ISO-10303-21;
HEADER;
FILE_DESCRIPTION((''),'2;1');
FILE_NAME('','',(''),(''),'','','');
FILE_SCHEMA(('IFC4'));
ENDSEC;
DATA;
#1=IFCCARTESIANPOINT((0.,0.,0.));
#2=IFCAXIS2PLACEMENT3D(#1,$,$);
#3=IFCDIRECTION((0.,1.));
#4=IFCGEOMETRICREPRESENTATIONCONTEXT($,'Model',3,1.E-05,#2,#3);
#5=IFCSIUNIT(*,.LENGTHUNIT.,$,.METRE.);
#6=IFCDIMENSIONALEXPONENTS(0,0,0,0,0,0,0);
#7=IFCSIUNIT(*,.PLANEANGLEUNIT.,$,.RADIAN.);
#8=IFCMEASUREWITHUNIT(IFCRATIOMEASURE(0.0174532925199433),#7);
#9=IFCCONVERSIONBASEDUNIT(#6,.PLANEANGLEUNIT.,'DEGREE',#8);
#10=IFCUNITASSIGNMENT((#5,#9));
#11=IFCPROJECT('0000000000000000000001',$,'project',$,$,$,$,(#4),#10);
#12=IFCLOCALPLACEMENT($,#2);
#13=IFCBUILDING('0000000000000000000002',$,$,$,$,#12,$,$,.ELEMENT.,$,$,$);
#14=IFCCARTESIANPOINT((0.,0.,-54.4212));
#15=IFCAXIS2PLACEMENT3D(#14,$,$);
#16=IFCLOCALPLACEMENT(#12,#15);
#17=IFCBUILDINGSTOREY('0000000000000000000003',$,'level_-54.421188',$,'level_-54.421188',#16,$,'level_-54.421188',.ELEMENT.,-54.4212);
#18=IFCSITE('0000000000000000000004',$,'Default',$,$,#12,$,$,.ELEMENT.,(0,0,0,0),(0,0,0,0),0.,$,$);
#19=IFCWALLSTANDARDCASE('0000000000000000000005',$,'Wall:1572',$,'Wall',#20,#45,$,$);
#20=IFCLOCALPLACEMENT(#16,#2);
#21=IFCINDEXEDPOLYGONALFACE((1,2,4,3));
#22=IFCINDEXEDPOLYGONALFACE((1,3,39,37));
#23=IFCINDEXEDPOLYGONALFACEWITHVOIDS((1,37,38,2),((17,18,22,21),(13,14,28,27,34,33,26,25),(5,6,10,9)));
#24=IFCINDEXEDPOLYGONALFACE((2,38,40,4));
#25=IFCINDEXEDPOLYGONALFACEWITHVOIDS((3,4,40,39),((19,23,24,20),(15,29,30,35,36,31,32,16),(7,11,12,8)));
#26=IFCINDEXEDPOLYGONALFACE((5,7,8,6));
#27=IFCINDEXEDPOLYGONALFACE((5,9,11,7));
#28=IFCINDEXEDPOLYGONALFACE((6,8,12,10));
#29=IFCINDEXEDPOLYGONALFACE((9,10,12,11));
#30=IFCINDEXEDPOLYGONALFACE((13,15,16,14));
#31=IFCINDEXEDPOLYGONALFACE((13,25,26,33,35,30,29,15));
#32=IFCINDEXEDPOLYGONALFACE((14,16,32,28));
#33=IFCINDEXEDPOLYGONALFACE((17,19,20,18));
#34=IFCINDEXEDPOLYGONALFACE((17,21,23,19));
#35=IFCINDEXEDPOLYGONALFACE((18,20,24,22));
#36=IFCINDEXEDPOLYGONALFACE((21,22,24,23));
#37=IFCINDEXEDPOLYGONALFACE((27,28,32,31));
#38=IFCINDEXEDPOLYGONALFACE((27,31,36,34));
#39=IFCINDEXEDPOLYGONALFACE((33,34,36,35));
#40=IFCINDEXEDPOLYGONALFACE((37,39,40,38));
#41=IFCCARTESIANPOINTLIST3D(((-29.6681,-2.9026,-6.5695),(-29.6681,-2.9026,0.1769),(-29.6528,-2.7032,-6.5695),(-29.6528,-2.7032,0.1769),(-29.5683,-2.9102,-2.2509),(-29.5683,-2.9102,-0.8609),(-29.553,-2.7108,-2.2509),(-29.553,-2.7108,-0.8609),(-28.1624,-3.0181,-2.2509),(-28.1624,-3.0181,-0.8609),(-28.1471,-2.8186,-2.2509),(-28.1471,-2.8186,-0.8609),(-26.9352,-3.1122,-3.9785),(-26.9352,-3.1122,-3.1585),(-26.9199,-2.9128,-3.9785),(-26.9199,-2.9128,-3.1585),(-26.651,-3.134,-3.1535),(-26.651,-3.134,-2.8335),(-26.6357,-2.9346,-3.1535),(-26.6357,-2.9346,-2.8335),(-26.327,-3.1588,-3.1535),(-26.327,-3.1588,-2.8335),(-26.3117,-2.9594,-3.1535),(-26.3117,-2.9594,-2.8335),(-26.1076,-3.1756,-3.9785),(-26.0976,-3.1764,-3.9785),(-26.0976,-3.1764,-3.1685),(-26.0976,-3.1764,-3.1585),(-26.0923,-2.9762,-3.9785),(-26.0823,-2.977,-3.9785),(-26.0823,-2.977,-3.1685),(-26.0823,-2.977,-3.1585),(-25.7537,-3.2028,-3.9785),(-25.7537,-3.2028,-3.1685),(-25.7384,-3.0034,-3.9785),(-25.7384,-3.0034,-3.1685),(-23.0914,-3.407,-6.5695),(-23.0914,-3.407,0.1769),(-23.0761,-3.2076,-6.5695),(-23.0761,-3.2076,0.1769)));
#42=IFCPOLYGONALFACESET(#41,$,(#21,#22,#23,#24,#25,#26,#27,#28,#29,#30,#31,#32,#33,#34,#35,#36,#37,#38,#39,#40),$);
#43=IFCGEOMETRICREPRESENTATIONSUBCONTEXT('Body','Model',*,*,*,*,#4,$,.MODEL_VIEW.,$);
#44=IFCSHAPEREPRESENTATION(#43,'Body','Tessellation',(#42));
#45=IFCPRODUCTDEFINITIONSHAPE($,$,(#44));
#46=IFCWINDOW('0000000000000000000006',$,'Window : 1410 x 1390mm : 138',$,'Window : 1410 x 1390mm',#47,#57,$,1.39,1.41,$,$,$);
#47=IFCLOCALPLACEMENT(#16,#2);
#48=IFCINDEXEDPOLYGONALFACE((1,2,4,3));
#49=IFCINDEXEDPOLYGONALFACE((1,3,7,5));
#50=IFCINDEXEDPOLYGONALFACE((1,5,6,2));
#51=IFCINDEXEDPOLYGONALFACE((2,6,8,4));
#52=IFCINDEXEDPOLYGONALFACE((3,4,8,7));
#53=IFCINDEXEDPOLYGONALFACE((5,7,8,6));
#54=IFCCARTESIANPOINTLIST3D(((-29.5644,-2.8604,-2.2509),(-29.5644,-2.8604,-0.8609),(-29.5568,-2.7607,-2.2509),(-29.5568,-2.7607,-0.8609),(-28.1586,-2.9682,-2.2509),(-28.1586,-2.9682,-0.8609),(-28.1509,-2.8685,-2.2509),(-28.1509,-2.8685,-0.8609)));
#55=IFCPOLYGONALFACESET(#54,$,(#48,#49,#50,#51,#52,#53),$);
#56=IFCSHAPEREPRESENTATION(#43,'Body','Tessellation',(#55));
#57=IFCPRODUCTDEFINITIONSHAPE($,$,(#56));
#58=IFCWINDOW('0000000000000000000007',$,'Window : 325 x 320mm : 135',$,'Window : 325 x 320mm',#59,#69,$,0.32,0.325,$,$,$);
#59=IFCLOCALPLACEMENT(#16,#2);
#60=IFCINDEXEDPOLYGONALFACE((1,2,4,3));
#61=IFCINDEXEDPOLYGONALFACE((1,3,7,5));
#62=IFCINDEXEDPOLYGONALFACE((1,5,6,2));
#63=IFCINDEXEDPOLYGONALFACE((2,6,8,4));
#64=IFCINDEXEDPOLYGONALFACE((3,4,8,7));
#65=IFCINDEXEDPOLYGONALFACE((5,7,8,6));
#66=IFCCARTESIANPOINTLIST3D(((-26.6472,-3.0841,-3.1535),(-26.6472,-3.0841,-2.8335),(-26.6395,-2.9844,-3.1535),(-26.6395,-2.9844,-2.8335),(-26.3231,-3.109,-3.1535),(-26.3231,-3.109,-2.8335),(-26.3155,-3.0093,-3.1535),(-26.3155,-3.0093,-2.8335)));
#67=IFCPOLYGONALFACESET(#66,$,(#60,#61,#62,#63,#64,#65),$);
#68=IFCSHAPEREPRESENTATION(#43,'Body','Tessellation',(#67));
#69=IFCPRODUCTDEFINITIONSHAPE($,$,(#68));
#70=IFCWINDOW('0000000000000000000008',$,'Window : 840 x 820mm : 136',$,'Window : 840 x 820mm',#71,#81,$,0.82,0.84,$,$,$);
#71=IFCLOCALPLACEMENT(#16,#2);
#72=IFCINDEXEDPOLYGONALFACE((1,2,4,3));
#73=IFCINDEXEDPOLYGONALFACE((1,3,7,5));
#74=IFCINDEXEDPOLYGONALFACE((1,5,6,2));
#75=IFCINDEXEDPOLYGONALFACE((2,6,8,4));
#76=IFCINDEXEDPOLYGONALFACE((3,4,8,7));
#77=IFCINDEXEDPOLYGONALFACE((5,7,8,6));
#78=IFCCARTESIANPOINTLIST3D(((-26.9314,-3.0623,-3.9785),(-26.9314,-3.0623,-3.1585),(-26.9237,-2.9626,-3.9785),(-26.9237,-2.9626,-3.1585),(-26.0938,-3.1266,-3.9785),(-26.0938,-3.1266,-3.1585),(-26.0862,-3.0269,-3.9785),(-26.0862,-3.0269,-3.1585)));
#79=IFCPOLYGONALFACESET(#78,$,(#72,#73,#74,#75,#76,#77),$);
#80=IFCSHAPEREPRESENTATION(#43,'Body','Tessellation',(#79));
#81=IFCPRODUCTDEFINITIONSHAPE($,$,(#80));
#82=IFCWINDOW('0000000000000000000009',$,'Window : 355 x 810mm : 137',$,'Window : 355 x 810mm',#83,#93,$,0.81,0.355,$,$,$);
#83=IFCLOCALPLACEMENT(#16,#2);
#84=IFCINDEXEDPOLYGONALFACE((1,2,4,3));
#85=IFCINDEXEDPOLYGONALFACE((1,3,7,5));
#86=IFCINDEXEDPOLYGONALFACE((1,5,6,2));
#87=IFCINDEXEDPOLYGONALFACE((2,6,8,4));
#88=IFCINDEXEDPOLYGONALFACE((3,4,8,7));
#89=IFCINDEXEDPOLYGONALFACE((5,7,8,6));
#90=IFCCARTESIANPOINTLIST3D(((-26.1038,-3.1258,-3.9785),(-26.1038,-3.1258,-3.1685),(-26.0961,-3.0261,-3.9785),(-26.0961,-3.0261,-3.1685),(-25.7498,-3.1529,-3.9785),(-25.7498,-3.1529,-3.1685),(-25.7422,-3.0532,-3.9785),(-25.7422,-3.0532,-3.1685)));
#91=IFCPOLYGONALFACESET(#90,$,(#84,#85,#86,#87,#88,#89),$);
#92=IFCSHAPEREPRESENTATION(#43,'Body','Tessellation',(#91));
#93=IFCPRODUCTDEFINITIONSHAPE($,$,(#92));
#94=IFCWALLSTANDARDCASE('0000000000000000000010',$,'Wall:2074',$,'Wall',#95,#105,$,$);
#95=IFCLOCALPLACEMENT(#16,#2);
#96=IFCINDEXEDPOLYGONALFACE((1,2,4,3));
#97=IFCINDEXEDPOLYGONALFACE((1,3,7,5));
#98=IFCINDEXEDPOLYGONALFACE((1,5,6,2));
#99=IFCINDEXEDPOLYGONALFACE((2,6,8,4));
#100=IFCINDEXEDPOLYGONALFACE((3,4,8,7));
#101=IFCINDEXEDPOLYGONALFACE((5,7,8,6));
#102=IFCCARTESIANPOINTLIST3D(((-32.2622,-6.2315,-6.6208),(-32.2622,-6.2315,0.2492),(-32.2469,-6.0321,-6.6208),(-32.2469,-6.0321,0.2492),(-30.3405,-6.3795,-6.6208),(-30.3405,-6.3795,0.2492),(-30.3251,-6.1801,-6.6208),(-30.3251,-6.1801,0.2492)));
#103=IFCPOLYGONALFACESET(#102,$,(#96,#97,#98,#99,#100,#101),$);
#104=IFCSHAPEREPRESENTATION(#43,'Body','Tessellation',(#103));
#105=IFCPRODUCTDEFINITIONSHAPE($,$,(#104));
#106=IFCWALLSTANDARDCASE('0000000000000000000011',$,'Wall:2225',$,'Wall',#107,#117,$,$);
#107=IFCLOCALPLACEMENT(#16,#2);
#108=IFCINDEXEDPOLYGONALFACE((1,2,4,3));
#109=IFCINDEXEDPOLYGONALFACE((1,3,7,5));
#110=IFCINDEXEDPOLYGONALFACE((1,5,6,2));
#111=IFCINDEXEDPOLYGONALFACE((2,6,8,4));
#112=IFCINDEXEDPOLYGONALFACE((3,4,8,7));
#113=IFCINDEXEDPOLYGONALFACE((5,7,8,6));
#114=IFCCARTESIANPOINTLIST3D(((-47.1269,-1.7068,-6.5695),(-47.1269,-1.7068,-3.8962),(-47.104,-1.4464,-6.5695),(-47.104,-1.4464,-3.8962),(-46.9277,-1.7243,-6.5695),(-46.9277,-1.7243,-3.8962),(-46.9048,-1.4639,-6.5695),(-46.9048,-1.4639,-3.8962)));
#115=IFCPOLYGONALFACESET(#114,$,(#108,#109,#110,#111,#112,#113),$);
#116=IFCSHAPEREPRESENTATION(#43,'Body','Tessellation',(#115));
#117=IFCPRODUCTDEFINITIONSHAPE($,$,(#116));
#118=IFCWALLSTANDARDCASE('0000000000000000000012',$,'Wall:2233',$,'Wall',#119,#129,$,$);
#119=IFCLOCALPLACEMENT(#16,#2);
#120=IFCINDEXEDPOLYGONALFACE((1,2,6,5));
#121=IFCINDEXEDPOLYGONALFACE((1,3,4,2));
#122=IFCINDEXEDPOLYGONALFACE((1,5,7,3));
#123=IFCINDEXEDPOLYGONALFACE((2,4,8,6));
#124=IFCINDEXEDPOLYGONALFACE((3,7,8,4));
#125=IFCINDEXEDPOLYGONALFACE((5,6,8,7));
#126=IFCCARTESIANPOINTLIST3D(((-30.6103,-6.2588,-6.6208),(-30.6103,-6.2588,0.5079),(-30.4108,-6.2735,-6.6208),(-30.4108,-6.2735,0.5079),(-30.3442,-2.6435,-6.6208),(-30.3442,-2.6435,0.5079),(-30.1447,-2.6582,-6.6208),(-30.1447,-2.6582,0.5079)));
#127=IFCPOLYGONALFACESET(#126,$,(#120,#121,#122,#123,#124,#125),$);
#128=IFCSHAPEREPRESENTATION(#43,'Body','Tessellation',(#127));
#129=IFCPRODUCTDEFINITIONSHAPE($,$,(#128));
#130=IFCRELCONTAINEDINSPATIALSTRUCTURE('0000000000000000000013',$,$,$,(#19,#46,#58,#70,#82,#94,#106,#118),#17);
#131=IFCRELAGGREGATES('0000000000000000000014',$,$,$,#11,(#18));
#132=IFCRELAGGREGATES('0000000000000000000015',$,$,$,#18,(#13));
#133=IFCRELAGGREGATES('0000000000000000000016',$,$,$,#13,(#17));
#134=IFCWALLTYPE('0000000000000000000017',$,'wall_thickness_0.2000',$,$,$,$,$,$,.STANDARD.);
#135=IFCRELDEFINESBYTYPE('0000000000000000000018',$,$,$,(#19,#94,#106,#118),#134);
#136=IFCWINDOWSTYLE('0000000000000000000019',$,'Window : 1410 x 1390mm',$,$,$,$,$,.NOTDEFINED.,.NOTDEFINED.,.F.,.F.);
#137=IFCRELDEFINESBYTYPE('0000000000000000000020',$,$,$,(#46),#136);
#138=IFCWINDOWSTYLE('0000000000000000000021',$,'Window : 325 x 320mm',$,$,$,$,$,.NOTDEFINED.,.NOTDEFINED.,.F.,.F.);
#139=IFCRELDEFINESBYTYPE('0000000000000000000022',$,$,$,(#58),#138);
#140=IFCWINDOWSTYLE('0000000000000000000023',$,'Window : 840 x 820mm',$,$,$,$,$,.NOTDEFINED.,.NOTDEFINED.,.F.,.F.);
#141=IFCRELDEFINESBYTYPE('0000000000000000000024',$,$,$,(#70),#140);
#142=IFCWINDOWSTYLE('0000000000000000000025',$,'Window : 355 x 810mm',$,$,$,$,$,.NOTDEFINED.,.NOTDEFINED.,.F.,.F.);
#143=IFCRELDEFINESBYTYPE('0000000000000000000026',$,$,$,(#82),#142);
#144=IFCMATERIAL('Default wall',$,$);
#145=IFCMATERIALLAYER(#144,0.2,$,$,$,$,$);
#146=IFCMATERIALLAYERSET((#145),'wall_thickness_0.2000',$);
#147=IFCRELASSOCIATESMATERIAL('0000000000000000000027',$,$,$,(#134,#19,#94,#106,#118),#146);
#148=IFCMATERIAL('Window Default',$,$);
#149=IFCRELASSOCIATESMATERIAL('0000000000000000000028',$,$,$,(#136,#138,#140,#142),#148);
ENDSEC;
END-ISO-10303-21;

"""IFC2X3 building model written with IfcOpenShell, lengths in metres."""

from ifc_helpers import new_model, entity, si_unit, converted_unit, direction, frame, frame_2d, origin, origin_2d_with_axis, place, context, subcontext, project, spatial, polyline, rectangle, outline, extrude, source, transform, mapped, material, layer, layer_set, layer_usage, type_object, type_shapes, element, fill, save


model = new_model("IFC2X3")

# Units and contexts
model_context = context("Model", 3, precision=1e-05, world=origin(), true_north=direction((0.0, 1.0)))
body_context = subcontext(model_context, "Body", "Model", "MODEL_VIEW")
ifc_project = project(units=[si_unit("LENGTHUNIT", "METRE"), converted_unit("PLANEANGLEUNIT", "DEGREE", entity("IfcRatioMeasure", 0.0174532925199433), si_unit("PLANEANGLEUNIT", "RADIAN"), dimensions=[0, 0, 0, 0, 0, 0, 0])], contexts=[model_context])

# Site, building, storey
placement_1 = place(None, origin())
site = spatial("IfcSite", under=ifc_project, at=placement_1, Name="Default", CompositionType="ELEMENT", RefLatitude=(0, 0, 0, 0), RefLongitude=(0, 0, 0, 0), RefElevation=0.0)
building = spatial("IfcBuilding", under=site, at=placement_1, CompositionType="ELEMENT")
storey_placement = place(placement_1, frame((0.0, 0.0, -54.4212)))
storey = spatial("IfcBuildingStorey", under=building, at=storey_placement, Name="level_-54.421188", ObjectType="level_-54.421188", LongName="level_-54.421188", CompositionType="ELEMENT", Elevation=-54.4212)

# Shared definitions
ifc_material_1 = material(Name="Default wall")
ifc_layer = layer(ifc_material_1, 0.2)
ifc_layer_set = layer_set([ifc_layer], Name="wall_thickness_0.2000")
ifc_layer_usage = layer_usage(ifc_layer_set, "AXIS2", "POSITIVE", -0.1)
wall_type = type_object("IfcWallType", Name="wall_thickness_0.2000", PredefinedType="STANDARD", material=ifc_layer_set)

# Wall, openings, windows
placement_2 = place(placement_1, frame((0.0, 0.0, -60.9907)))
wall_1_placement = place(placement_2, frame((-29.6605, -2.8029, 0.0), z_axis=(0.0, 0.0, 1.0), x_axis=(0.997072, -0.07647, 0.0)))
wall_1 = element("IfcWallStandardCase", 1, at=wall_1_placement, inside=storey, type_object=wall_type, material=ifc_layer_usage, Name="Wall:1572", ObjectType="Wall", context=body_context, shape_type="SweptSolid", body=[
    extrude(outline(polyline([(6.596, -0.1), (6.596, 0.1), (0.0, 0.1), (0.0, -0.1), (6.596, -0.1)])), origin(), (0.0, 0.0, 1.0), 6.7464),
])
opening_1_placement = place(wall_1_placement, frame((3.026, -0.1, 3.416)))
opening_1 = element("IfcOpeningElement", 2, at=opening_1_placement, cuts=wall_1, ObjectType="Opening", context=body_context, shape_type="SweptSolid", body=[
    extrude(rectangle(XDim=0.325, YDim=0.32, at=frame_2d((0.16, 0.1625), x_axis=(0.0, 1.0))), frame((0.0, 0.0, 0.0), z_axis=(0.0, 1.0, 0.0), x_axis=(0.0, 0.0, 1.0)), (0.0, 0.0, 1.0), 0.2),
])
opening_2_placement = place(wall_1_placement, frame((2.741, -0.1, 2.591)))
opening_2 = element("IfcOpeningElement", 3, at=opening_2_placement, cuts=wall_1, ObjectType="Opening", context=body_context, shape_type="SweptSolid", body=[
    extrude(rectangle(XDim=0.84, YDim=0.82, at=frame_2d((0.41, 0.42), x_axis=(0.0, 1.0))), frame((0.0, 0.0, 0.0), z_axis=(0.0, 1.0, 0.0), x_axis=(0.0, 0.0, 1.0)), (0.0, 0.0, 1.0), 0.2),
])
opening_3_placement = place(wall_1_placement, frame((3.571, -0.1, 2.591)))
opening_3 = element("IfcOpeningElement", 4, at=opening_3_placement, cuts=wall_1, ObjectType="Opening", context=body_context, shape_type="SweptSolid", body=[
    extrude(rectangle(XDim=0.355, YDim=0.81, at=frame_2d((0.405, 0.1775), x_axis=(0.0, 1.0))), frame((0.0, 0.0, 0.0), z_axis=(0.0, 1.0, 0.0), x_axis=(0.0, 0.0, 1.0)), (0.0, 0.0, 1.0), 0.2),
])
opening_4_placement = place(wall_1_placement, frame((0.1002, -0.1, 4.3186)))
opening_4 = element("IfcOpeningElement", 5, at=opening_4_placement, cuts=wall_1, ObjectType="Opening", context=body_context, shape_type="SweptSolid", body=[
    extrude(rectangle(XDim=1.41, YDim=1.39, at=frame_2d((0.695, 0.705), x_axis=(0.0, 1.0))), frame((0.0, 0.0, 0.0), z_axis=(0.0, 1.0, 0.0), x_axis=(0.0, 0.0, 1.0)), (0.0, 0.0, 1.0), 0.2),
])
ifc_material_2 = material(Name="Window Default")
window_style_1 = type_object("IfcWindowStyle", Name="Window : 1410 x 1390mm", ConstructionType="NOTDEFINED", OperationType="NOTDEFINED", ParameterTakesPrecedence=False, Sizeable=False, material=ifc_material_2)
shared_shape_1 = source(origin(), body_context, "Body", "SweptSolid", [
    extrude(rectangle(XDim=0.1, YDim=1.41, at=origin_2d_with_axis()), frame((0.705, 0.1, 0.0), z_axis=(0.0, 0.0, 1.0), x_axis=(0.0, 1.0, 0.0)), (0.0, 0.0, 1.0), 1.39),
])
type_shapes(window_style_1, [shared_shape_1])
window_1_placement = place(opening_4_placement, origin())
window_1 = element("IfcWindow", 6, at=window_1_placement, inside=storey, type_object=window_style_1, Name="Window : 1410 x 1390mm : 138", ObjectType="Window : 1410 x 1390mm", OverallHeight=1.39, OverallWidth=1.41, context=body_context, shape_type="MappedRepresentation", body=[
    mapped(shared_shape_1, transform((0.0, 0.0, 0.0), scale=1.0)),
])
fill(opening_4, window_1)
window_style_2 = type_object("IfcWindowStyle", Name="Window : 325 x 320mm", ConstructionType="NOTDEFINED", OperationType="NOTDEFINED", ParameterTakesPrecedence=False, Sizeable=False, material=ifc_material_2)
shared_shape_2 = source(origin(), body_context, "Body", "SweptSolid", [
    extrude(rectangle(XDim=0.1, YDim=0.325, at=origin_2d_with_axis()), frame((0.1625, 0.1, 0.0), z_axis=(0.0, 0.0, 1.0), x_axis=(0.0, 1.0, 0.0)), (0.0, 0.0, 1.0), 0.32),
])
type_shapes(window_style_2, [shared_shape_2])
window_2_placement = place(opening_1_placement, origin())
window_2 = element("IfcWindow", 7, at=window_2_placement, inside=storey, type_object=window_style_2, Name="Window : 325 x 320mm : 135", ObjectType="Window : 325 x 320mm", OverallHeight=0.32, OverallWidth=0.325, context=body_context, shape_type="MappedRepresentation", body=[
    mapped(shared_shape_2, transform((0.0, 0.0, 0.0), scale=1.0)),
])
fill(opening_1, window_2)
window_style_3 = type_object("IfcWindowStyle", Name="Window : 840 x 820mm", ConstructionType="NOTDEFINED", OperationType="NOTDEFINED", ParameterTakesPrecedence=False, Sizeable=False, material=ifc_material_2)
shared_shape_3 = source(origin(), body_context, "Body", "SweptSolid", [
    extrude(rectangle(XDim=0.1, YDim=0.84, at=origin_2d_with_axis()), frame((0.42, 0.1, 0.0), z_axis=(0.0, 0.0, 1.0), x_axis=(0.0, 1.0, 0.0)), (0.0, 0.0, 1.0), 0.82),
])
type_shapes(window_style_3, [shared_shape_3])
window_3_placement = place(opening_2_placement, origin())
window_3 = element("IfcWindow", 8, at=window_3_placement, inside=storey, type_object=window_style_3, Name="Window : 840 x 820mm : 136", ObjectType="Window : 840 x 820mm", OverallHeight=0.82, OverallWidth=0.84, context=body_context, shape_type="MappedRepresentation", body=[
    mapped(shared_shape_3, transform((0.0, 0.0, 0.0), scale=1.0)),
])
fill(opening_2, window_3)
window_style_4 = type_object("IfcWindowStyle", Name="Window : 355 x 810mm", ConstructionType="NOTDEFINED", OperationType="NOTDEFINED", ParameterTakesPrecedence=False, Sizeable=False, material=ifc_material_2)
shared_shape_4 = source(origin(), body_context, "Body", "SweptSolid", [
    extrude(rectangle(XDim=0.1, YDim=0.355, at=origin_2d_with_axis()), frame((0.1775, 0.1, 0.0), z_axis=(0.0, 0.0, 1.0), x_axis=(0.0, 1.0, 0.0)), (0.0, 0.0, 1.0), 0.81),
])
type_shapes(window_style_4, [shared_shape_4])
window_4_placement = place(opening_3_placement, origin())
window_4 = element("IfcWindow", 9, at=window_4_placement, inside=storey, type_object=window_style_4, Name="Window : 355 x 810mm : 137", ObjectType="Window : 355 x 810mm", OverallHeight=0.81, OverallWidth=0.355, context=body_context, shape_type="MappedRepresentation", body=[
    mapped(shared_shape_4, transform((0.0, 0.0, 0.0), scale=1.0)),
])
fill(opening_3, window_4)

# Walls
placement_3 = place(placement_1, frame((0.0, 0.0, -61.042)))
wall_2_placement = place(placement_3, frame((-30.3328, -6.2798, 0.0), z_axis=(0.0, 0.0, 1.0), x_axis=(-0.997045, 0.076824, 0.0)))
element("IfcWallStandardCase", 10, at=wall_2_placement, inside=storey, type_object=wall_type, material=ifc_layer_usage, Name="Wall:2074", ObjectType="Wall", context=body_context, shape_type="SweptSolid", body=[
    extrude(outline(polyline([(1.9275, -0.1), (1.9275, 0.1), (0.0, 0.1), (0.0, -0.1), (1.9275, -0.1)])), origin(), (0.0, 0.0, 1.0), 6.8701),
])
placement_4 = place(placement_1, frame((0.0, 0.0, -60.9907)))
wall_3_placement = place(placement_4, frame((-47.0273, -1.7155, 0.0), z_axis=(0.0, 0.0, 1.0), x_axis=(0.087637, 0.996152, 0.0)))
element("IfcWallStandardCase", 11, at=wall_3_placement, inside=storey, type_object=wall_type, material=ifc_layer_usage, Name="Wall:2225", ObjectType="Wall", context=body_context, shape_type="SweptSolid", body=[
    extrude(outline(polyline([(0.2614, -0.1), (0.2614, 0.1), (0.0, 0.1), (0.0, -0.1), (0.2614, -0.1)])), origin(), (0.0, 0.0, 1.0), 2.6733),
])
placement_5 = place(placement_1, frame((0.0, 0.0, -61.042)))
wall_4_placement = place(placement_5, frame((-30.2445, -2.6508, 0.0), z_axis=(0.0, 0.0, 1.0), x_axis=(-0.073409, -0.997302, 0.0)))
element("IfcWallStandardCase", 12, at=wall_4_placement, inside=storey, type_object=wall_type, material=ifc_layer_usage, Name="Wall:2233", ObjectType="Wall", context=body_context, shape_type="SweptSolid", body=[
    extrude(outline(polyline([(3.6251, -0.1), (3.6251, 0.1), (0.0, 0.1), (0.0, -0.1), (3.6251, -0.1)])), origin(), (0.0, 0.0, 1.0), 7.1287),
])

save(model, "model.ifc")
